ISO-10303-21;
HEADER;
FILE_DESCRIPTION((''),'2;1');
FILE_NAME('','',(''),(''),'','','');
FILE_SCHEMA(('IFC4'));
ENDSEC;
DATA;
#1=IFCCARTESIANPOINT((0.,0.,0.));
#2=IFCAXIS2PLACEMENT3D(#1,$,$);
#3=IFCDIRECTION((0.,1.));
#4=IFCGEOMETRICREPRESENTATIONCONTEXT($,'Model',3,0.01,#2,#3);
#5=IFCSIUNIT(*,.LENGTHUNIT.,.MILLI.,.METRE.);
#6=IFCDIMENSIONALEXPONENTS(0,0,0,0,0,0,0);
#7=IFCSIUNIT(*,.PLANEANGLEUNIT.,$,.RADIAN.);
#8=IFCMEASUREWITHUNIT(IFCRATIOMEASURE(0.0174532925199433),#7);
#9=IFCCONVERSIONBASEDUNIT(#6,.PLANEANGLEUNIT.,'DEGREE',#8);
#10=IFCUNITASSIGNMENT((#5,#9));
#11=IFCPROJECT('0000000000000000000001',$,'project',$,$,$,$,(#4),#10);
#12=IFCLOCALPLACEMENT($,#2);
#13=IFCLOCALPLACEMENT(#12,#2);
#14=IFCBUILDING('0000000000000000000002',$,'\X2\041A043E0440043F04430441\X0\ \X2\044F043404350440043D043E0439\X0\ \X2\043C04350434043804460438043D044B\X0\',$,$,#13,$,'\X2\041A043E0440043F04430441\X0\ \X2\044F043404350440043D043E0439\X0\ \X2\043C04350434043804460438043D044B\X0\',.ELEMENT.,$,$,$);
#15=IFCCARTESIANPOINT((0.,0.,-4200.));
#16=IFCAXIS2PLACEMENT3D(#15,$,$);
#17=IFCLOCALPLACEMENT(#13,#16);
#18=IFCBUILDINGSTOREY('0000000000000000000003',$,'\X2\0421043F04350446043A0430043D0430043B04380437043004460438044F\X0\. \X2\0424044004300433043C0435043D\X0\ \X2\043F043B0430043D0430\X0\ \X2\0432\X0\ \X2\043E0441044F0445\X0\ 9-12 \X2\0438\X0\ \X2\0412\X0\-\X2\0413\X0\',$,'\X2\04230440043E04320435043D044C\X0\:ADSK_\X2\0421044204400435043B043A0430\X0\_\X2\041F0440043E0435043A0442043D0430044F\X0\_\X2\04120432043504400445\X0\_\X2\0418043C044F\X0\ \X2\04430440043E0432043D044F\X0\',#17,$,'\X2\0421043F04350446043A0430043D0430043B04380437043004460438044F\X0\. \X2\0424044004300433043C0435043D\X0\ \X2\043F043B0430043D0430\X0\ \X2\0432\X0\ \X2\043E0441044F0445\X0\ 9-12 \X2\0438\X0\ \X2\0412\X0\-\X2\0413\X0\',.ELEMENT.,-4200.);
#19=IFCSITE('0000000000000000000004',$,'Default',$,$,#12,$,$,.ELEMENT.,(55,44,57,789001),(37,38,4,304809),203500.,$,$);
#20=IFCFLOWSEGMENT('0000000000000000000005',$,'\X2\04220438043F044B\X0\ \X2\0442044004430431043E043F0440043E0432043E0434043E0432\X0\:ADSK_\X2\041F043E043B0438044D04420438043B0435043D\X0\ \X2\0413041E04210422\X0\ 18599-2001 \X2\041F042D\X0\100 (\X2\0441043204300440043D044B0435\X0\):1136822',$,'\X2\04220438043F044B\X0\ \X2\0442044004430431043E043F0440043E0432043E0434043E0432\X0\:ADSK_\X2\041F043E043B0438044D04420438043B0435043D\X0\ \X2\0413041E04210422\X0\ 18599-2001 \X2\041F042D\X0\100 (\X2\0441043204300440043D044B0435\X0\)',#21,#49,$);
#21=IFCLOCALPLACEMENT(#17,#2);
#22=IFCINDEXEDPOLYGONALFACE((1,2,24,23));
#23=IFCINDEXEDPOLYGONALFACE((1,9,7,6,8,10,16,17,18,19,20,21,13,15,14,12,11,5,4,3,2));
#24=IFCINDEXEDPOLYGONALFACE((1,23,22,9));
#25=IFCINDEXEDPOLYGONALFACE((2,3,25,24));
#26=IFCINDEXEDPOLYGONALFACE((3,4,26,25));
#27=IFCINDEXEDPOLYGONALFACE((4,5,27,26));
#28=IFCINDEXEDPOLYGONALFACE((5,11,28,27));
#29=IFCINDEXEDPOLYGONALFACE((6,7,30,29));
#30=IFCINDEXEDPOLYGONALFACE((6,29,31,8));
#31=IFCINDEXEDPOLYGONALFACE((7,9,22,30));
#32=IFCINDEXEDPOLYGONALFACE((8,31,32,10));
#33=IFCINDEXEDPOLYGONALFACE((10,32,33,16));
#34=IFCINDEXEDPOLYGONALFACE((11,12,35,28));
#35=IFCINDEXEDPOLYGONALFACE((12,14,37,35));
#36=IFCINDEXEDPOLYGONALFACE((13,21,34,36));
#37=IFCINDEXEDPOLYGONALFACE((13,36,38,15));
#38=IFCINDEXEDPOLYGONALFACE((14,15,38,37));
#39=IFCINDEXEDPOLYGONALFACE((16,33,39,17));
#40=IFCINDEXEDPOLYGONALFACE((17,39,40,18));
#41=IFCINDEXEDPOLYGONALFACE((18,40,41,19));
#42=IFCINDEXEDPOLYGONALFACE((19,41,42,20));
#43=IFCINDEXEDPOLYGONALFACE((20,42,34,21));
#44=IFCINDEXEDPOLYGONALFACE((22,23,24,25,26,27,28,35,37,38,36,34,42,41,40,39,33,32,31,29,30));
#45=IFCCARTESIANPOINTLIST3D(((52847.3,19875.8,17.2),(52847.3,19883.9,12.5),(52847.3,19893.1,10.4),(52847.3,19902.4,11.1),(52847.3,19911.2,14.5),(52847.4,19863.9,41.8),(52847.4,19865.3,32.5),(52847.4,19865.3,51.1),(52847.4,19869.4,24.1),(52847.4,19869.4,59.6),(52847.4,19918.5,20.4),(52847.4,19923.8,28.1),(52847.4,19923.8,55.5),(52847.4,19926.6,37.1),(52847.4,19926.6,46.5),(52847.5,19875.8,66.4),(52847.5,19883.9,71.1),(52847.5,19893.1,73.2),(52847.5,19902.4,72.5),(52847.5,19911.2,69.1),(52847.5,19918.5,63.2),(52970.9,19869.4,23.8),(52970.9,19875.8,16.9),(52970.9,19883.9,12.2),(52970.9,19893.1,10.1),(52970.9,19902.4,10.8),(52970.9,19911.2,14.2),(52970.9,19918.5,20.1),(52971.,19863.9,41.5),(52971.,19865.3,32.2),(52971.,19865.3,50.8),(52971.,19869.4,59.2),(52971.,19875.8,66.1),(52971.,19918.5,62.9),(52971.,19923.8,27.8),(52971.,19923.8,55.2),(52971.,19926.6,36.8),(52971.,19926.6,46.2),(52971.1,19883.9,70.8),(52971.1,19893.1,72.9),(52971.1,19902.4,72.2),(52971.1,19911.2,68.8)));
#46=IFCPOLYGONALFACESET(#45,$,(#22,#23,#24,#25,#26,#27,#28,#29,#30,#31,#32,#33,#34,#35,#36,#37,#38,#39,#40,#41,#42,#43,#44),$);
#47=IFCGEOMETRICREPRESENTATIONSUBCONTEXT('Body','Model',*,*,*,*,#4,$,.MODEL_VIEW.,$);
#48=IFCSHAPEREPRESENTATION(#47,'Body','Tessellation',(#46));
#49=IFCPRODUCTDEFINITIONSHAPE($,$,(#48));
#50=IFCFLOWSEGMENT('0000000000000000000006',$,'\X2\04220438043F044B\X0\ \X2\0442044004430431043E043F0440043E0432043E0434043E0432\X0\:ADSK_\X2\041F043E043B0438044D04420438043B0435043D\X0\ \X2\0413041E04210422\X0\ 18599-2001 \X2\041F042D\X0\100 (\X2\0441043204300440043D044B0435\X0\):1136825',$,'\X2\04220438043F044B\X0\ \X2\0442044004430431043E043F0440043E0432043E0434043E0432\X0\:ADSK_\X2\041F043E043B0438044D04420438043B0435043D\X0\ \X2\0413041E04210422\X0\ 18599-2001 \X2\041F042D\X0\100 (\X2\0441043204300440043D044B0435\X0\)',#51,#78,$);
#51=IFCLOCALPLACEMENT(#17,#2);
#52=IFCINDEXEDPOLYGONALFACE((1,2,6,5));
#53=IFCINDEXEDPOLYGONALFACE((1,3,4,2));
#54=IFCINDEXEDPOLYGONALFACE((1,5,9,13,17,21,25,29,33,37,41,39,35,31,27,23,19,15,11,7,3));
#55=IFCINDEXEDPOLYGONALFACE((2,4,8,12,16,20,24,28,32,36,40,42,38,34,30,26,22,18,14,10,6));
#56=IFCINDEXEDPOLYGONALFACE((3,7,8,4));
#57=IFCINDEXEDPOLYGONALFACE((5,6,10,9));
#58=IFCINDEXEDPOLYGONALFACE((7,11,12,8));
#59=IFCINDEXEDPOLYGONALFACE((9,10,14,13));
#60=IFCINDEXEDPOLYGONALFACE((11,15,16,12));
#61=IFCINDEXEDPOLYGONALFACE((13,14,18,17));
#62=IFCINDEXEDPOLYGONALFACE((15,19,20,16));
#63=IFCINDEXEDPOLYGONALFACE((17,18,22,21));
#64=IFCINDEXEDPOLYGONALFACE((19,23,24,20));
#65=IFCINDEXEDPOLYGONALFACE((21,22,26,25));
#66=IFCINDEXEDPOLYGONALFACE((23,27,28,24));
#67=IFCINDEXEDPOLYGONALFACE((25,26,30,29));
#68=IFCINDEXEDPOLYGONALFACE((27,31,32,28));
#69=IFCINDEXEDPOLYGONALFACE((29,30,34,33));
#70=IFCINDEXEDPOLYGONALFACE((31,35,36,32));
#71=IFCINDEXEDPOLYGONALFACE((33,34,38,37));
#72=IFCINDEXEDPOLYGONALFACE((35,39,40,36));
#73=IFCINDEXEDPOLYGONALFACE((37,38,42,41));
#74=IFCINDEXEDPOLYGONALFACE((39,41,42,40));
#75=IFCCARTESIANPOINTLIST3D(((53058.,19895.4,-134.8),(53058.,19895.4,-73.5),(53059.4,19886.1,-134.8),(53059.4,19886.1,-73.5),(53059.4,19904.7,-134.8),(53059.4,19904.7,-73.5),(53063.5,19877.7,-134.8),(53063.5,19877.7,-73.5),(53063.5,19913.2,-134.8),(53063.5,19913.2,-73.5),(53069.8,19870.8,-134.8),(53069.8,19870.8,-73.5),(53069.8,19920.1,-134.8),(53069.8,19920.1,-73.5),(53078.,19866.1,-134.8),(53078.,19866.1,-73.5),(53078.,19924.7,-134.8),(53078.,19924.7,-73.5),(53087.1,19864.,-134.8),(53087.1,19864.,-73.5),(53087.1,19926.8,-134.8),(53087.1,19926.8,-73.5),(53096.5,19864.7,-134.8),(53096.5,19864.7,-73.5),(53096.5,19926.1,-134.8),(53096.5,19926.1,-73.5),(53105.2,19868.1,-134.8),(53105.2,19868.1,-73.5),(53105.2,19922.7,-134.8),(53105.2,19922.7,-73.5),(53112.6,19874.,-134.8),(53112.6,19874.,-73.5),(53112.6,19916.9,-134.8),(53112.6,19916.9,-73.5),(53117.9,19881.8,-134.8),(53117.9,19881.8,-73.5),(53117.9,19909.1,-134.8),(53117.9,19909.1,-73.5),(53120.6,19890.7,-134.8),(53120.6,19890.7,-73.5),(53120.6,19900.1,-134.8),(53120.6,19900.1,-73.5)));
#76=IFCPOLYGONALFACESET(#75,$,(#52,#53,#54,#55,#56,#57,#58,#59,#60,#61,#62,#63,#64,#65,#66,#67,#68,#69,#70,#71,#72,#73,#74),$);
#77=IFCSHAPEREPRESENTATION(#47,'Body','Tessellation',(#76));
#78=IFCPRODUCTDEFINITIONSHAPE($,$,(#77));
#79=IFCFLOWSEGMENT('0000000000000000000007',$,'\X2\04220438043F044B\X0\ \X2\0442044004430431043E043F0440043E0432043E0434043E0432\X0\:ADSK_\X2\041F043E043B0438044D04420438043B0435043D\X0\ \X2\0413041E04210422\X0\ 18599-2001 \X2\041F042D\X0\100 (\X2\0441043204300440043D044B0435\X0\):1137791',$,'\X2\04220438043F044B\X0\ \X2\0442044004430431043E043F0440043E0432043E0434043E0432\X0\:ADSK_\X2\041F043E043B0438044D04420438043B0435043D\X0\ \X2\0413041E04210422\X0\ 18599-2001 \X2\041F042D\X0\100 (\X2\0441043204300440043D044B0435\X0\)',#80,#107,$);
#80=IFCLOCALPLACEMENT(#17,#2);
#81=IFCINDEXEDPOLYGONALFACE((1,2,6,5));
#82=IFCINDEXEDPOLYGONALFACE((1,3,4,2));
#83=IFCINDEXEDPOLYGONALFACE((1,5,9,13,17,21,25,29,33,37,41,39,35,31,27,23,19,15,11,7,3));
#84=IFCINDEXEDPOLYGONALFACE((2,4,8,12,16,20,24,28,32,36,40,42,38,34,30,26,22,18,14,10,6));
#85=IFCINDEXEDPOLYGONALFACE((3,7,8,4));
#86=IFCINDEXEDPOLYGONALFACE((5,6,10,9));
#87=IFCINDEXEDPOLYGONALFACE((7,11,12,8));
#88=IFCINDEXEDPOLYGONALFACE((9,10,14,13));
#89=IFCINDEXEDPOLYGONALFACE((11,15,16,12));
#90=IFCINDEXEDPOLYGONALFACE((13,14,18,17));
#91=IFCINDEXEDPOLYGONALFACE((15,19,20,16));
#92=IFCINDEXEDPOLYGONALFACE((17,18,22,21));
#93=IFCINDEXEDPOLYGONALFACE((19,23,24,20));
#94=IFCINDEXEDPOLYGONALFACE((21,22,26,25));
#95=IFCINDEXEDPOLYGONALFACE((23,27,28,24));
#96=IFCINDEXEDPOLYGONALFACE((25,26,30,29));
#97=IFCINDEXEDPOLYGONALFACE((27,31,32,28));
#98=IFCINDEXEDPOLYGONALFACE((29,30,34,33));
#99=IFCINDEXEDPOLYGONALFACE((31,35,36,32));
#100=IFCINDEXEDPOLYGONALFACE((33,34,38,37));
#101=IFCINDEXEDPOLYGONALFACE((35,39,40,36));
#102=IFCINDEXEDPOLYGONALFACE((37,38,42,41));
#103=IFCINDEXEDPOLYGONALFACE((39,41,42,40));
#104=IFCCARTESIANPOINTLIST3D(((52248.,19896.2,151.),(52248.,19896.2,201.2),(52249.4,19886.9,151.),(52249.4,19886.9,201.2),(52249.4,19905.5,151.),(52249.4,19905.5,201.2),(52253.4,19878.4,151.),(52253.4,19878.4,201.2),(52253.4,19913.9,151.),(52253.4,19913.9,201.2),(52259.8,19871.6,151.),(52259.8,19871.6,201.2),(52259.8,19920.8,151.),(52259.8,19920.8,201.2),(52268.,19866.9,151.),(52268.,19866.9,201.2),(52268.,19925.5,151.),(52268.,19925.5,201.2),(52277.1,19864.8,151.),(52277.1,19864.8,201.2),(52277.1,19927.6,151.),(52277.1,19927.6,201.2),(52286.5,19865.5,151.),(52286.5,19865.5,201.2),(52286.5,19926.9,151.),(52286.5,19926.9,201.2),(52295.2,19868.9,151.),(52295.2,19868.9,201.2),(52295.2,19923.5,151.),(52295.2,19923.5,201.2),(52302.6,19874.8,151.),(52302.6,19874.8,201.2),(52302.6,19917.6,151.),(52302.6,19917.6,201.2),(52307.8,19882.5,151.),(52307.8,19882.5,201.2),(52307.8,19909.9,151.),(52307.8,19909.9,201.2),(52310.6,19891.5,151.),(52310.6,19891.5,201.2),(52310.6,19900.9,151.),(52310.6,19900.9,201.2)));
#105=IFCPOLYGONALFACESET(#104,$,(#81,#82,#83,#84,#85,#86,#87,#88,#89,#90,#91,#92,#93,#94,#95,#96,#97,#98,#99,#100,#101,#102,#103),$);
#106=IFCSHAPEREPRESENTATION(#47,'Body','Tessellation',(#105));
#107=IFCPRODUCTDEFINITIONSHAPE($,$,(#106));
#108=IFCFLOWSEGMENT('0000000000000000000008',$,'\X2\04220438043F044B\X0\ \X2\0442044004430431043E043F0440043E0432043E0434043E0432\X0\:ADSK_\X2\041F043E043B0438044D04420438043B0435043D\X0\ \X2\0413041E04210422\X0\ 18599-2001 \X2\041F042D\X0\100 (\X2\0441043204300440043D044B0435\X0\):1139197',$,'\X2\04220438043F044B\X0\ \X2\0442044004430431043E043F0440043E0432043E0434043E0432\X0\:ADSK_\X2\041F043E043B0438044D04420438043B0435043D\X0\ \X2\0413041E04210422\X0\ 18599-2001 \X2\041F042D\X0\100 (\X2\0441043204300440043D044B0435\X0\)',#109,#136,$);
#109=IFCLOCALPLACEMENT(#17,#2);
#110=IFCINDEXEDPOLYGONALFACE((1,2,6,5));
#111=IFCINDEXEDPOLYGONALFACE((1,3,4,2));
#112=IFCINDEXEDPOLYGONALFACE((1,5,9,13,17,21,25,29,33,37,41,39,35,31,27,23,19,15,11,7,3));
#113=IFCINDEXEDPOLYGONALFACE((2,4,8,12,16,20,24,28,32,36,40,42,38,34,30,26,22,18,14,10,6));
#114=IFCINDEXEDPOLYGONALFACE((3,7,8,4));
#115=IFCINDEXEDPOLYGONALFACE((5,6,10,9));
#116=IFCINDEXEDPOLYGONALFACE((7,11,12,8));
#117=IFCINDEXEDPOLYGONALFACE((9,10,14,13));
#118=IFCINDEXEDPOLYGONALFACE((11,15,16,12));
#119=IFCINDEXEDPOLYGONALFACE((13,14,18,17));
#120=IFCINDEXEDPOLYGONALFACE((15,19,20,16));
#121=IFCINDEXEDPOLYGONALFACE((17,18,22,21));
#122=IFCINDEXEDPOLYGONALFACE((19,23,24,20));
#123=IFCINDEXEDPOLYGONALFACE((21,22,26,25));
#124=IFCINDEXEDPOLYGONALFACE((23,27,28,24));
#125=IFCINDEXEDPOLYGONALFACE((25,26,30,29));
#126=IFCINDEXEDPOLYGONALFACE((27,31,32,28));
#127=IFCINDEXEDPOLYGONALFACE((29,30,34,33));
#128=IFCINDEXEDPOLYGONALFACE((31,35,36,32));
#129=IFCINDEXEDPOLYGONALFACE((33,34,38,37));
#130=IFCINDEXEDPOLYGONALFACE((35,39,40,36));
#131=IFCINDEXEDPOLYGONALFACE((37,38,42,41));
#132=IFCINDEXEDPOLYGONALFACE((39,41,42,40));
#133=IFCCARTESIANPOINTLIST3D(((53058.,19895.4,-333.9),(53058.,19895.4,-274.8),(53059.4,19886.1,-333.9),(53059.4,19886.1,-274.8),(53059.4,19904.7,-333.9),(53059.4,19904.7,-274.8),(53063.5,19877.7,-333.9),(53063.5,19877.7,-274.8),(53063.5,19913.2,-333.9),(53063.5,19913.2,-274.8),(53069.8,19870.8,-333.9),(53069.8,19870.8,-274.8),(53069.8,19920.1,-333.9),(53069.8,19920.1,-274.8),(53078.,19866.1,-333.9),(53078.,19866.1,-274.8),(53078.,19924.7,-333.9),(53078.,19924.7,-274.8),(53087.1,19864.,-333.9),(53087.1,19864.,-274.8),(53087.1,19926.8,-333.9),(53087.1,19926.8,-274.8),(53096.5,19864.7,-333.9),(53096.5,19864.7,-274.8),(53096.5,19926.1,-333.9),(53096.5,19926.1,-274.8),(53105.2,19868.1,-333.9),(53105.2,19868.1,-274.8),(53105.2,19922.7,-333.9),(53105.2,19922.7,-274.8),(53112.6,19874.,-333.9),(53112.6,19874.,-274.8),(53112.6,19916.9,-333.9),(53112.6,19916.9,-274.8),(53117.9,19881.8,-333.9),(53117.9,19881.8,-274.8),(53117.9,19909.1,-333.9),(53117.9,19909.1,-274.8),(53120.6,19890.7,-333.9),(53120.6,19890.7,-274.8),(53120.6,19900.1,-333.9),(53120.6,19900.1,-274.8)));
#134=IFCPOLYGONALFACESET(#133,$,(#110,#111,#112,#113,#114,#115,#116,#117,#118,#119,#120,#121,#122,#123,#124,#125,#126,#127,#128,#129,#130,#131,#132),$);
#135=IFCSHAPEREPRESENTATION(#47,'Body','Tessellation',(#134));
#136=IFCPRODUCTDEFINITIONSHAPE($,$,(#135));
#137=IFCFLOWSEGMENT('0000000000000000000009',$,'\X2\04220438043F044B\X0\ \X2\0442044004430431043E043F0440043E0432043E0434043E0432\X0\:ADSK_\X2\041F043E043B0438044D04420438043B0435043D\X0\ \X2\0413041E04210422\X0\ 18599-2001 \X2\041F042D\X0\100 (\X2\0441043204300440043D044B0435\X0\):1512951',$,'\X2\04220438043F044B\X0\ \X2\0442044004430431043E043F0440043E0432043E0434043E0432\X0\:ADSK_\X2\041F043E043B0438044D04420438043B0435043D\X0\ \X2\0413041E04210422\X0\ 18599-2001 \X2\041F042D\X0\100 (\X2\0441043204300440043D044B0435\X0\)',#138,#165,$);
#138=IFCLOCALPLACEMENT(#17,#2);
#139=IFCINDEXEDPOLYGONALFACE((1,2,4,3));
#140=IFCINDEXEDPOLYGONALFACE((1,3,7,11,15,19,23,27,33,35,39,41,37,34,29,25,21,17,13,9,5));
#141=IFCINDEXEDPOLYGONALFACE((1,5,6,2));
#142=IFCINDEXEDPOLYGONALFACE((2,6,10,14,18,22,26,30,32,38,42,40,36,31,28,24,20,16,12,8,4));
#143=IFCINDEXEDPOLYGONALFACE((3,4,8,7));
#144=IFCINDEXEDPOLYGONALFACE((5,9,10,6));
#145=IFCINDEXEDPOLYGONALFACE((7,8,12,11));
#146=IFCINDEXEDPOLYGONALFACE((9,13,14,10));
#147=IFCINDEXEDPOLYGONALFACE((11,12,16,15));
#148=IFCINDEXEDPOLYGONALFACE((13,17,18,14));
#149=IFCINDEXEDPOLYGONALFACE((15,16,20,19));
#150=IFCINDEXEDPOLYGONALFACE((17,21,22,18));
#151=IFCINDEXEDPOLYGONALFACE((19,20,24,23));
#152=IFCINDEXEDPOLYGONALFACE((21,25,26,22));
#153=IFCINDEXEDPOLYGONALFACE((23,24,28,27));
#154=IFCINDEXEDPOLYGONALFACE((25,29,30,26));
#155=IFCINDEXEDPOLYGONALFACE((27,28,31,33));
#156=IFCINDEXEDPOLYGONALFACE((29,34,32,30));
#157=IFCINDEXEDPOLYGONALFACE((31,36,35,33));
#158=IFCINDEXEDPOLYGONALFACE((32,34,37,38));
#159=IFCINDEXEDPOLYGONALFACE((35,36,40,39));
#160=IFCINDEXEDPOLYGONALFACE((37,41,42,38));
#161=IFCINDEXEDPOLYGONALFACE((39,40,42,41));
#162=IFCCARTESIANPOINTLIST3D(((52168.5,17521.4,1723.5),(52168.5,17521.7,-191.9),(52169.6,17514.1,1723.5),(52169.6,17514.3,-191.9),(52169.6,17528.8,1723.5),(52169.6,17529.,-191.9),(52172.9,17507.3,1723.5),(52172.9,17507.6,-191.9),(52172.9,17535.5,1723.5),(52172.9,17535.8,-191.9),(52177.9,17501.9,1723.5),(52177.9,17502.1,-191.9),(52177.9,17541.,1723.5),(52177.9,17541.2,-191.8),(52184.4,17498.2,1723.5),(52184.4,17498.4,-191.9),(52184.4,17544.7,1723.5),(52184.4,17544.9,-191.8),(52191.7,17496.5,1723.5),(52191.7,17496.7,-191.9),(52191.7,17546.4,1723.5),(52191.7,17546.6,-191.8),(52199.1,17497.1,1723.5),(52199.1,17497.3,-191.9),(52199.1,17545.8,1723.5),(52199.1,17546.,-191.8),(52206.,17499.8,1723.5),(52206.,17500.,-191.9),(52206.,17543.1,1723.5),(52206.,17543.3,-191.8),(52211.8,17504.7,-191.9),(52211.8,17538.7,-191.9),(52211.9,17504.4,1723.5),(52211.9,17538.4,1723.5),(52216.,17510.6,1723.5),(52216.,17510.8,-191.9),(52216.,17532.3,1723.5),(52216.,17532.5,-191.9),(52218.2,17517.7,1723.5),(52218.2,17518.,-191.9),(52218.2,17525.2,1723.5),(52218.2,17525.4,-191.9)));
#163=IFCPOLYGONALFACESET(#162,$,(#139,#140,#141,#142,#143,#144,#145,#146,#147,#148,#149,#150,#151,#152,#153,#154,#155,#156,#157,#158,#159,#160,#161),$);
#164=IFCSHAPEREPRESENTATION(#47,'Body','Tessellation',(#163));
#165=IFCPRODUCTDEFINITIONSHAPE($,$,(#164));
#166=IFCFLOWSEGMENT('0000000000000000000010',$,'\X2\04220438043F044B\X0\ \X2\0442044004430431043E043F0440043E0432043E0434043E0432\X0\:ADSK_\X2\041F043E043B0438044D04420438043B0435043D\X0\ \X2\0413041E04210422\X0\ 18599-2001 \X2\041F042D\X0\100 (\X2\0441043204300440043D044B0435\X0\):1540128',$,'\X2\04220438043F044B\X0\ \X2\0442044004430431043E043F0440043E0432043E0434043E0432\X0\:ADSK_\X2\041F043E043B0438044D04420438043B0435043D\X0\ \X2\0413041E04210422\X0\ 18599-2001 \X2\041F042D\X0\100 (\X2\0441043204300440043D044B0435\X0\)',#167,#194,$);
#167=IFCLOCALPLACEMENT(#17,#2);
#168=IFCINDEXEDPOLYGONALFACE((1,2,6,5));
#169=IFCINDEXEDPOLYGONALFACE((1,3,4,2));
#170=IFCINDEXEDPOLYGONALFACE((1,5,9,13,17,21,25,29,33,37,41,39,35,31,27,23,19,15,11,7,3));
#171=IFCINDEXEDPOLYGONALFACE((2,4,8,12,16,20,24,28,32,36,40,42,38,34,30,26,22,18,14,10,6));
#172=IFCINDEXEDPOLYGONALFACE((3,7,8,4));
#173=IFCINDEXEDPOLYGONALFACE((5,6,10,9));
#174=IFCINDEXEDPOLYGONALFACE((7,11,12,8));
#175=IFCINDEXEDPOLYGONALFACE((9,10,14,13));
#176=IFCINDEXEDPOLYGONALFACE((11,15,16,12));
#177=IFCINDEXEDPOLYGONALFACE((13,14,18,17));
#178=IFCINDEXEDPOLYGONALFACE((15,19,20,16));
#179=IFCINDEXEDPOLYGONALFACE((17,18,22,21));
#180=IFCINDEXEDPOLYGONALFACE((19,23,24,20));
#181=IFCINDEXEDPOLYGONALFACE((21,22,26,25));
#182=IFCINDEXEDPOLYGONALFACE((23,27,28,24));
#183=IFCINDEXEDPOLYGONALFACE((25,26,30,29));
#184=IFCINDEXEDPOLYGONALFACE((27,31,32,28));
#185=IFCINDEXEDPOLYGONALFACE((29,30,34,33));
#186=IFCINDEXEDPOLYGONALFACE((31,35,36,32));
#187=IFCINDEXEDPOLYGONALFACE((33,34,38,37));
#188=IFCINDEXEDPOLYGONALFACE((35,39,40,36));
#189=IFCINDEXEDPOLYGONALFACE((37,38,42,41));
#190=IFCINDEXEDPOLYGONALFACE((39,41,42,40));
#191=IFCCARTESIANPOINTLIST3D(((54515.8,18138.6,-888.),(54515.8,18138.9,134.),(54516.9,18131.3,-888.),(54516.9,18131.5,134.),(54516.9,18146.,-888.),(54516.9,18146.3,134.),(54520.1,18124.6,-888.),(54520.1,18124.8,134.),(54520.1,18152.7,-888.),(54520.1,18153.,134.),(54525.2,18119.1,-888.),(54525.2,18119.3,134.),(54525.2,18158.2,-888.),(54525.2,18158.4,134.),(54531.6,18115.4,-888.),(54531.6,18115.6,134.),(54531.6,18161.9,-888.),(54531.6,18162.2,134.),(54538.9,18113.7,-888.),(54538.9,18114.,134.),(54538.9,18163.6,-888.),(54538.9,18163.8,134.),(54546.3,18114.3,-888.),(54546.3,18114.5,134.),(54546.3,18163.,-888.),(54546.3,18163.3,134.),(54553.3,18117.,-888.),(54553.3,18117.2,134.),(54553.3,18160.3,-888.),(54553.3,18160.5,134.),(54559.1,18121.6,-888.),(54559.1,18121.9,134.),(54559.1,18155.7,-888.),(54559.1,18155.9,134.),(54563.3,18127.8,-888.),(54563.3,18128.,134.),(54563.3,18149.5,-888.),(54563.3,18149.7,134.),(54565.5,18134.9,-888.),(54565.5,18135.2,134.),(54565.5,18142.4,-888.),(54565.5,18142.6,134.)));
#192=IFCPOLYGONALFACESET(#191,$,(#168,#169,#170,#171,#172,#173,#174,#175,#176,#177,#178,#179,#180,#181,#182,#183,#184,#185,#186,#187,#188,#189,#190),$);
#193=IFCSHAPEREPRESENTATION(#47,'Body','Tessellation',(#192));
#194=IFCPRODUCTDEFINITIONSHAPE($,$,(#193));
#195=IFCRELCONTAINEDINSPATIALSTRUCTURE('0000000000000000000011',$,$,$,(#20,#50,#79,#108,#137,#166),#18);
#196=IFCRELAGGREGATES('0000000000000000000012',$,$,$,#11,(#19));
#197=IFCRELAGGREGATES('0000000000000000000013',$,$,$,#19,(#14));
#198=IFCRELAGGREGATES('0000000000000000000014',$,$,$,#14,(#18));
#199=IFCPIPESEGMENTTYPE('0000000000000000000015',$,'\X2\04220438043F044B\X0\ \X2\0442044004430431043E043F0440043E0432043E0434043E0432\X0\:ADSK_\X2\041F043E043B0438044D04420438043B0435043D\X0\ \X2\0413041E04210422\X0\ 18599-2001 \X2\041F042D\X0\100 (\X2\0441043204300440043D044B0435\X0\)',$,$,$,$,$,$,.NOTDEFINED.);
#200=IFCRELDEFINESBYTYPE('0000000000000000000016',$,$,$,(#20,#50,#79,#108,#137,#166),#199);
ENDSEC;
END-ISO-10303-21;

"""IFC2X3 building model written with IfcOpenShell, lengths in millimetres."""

from ifc_helpers import new_model, entity, si_unit, converted_unit, direction, frame, frame_2d, origin, origin_2d_with_axis, place, context, subcontext, project, spatial, circle, extrude, type_object, element, save


model = new_model("IFC2X3")

# Units and contexts
model_context = context("Model", 3, precision=0.01, world=origin(), true_north=direction((0.0, 1.0)))
body_context = subcontext(model_context, "Body", "Model", "MODEL_VIEW")
ifc_project = project(units=[si_unit("LENGTHUNIT", "METRE", prefix="MILLI"), converted_unit("PLANEANGLEUNIT", "DEGREE", entity("IfcRatioMeasure", 0.0174532925199433), si_unit("PLANEANGLEUNIT", "RADIAN"), dimensions=[0, 0, 0, 0, 0, 0, 0])], contexts=[model_context])

# Site, building, storey
site_placement = place(None, frame((0.0, 0.0, 0.0)))
site = spatial("IfcSite", under=ifc_project, at=site_placement, Name="Default", CompositionType="ELEMENT", RefLatitude=(55, 44, 57, 789001), RefLongitude=(37, 38, 4, 304809), RefElevation=203500.0)
building_placement = place(site_placement, origin())
building = spatial("IfcBuilding", under=site, at=building_placement, Name="Корпус ядерной медицины", LongName="Корпус ядерной медицины", CompositionType="ELEMENT")
storey_placement = place(building_placement, frame((0.0, 0.0, -4200.0)))
storey = spatial("IfcBuildingStorey", under=building, at=storey_placement, Name="Спецканализация. Фрагмен плана в осях 9-12 и В-Г", ObjectType="Уровень:ADSK_Стрелка_Проектная_Вверх_Имя уровня", LongName="Спецканализация. Фрагмен плана в осях 9-12 и В-Г", CompositionType="ELEMENT", Elevation=-4200.0)

# Flow segments
pipe_segment_type = type_object("IfcPipeSegmentType", Name="Типы трубопроводов:ADSK_Полиэтилен ГОСТ 18599-2001 ПЭ100 (сварные)", PredefinedType="NOTDEFINED")
flow_segment_1_placement = place(storey_placement, frame((52847.3, 19862.3, 8.4)))
element("IfcFlowSegment", 1, at=flow_segment_1_placement, inside=storey, type_object=pipe_segment_type, Name="Типы трубопроводов:ADSK_Полиэтилен ГОСТ 18599-2001 ПЭ100 (сварные):1136822", ObjectType="Типы трубопроводов:ADSK_Полиэтилен ГОСТ 18599-2001 ПЭ100 (сварные)", context=body_context, shape_type="SweptSolid", body=[
    extrude(circle(Radius=31.5, at=origin_2d_with_axis()), frame((0.1, 33.1, 33.4), z_axis=(0.999997, 0.0, -0.002457), x_axis=(0.0, -1.0, 0.0)), (0.0, 0.0, 1.0), 123.6),
])
flow_segment_2_placement = place(storey_placement, frame((53056.4, 19862.3, -134.8)))
element("IfcFlowSegment", 2, at=flow_segment_2_placement, inside=storey, type_object=pipe_segment_type, Name="Типы трубопроводов:ADSK_Полиэтилен ГОСТ 18599-2001 ПЭ100 (сварные):1136825", ObjectType="Типы трубопроводов:ADSK_Полиэтилен ГОСТ 18599-2001 ПЭ100 (сварные)", context=body_context, shape_type="SweptSolid", body=[
    extrude(circle(Radius=31.5, at=origin_2d_with_axis()), frame((33.1, 33.1, 0.0), z_axis=(-0.000005, 0.0, 1.0), x_axis=(-1.0, 0.0, -0.000005)), (0.0, 0.0, 1.0), 61.3),
])
flow_segment_3_placement = place(storey_placement, frame((52246.4, 19863.1, 151.0)))
element("IfcFlowSegment", 3, at=flow_segment_3_placement, inside=storey, type_object=pipe_segment_type, Name="Типы трубопроводов:ADSK_Полиэтилен ГОСТ 18599-2001 ПЭ100 (сварные):1137791", ObjectType="Типы трубопроводов:ADSK_Полиэтилен ГОСТ 18599-2001 ПЭ100 (сварные)", context=body_context, shape_type="SweptSolid", body=[
    extrude(circle(Radius=31.5, at=frame_2d((0.0, 0.0), x_axis=(1.0, 0.0))), frame((33.1, 33.1, 0.0), z_axis=(-0.000008, 0.0, 1.0), x_axis=(-1.0, 0.0, -0.000008)), (0.0, 0.0, 1.0), 50.2),
])
flow_segment_4_placement = place(storey_placement, frame((53056.4, 19862.3, -333.9)))
element("IfcFlowSegment", 4, at=flow_segment_4_placement, inside=storey, type_object=pipe_segment_type, Name="Типы трубопроводов:ADSK_Полиэтилен ГОСТ 18599-2001 ПЭ100 (сварные):1139197", ObjectType="Типы трубопроводов:ADSK_Полиэтилен ГОСТ 18599-2001 ПЭ100 (сварные)", context=body_context, shape_type="SweptSolid", body=[
    extrude(circle(Radius=31.5, at=origin_2d_with_axis()), frame((33.1, 33.1, 0.0), z_axis=(0.000005, 0.0, 1.0), x_axis=(-1.0, 0.0, 0.000005)), (0.0, 0.0, 1.0), 59.1),
])
flow_segment_5_placement = place(storey_placement, frame((52166.9, 17494.8, -191.9)))
element("IfcFlowSegment", 5, at=flow_segment_5_placement, inside=storey, type_object=pipe_segment_type, Name="Типы трубопроводов:ADSK_Полиэтилен ГОСТ 18599-2001 ПЭ100 (сварные):1512951", ObjectType="Типы трубопроводов:ADSK_Полиэтилен ГОСТ 18599-2001 ПЭ100 (сварные)", context=body_context, shape_type="SweptSolid", body=[
    extrude(circle(Radius=25.0, at=origin_2d_with_axis()), frame((26.6, 26.8, 0.0), z_axis=(0.000001, -0.00013, 1.0), x_axis=(-1.0, 0.0, 0.000001)), (0.0, 0.0, 1.0), 1915.3),
])
flow_segment_6_placement = place(storey_placement, frame((54514.2, 18112.1, -888.0)))
element("IfcFlowSegment", 6, at=flow_segment_6_placement, inside=storey, type_object=pipe_segment_type, Name="Типы трубопроводов:ADSK_Полиэтилен ГОСТ 18599-2001 ПЭ100 (сварные):1540128", ObjectType="Типы трубопроводов:ADSK_Полиэтилен ГОСТ 18599-2001 ПЭ100 (сварные)", context=body_context, shape_type="SweptSolid", body=[
    extrude(circle(Radius=25.0, at=frame_2d((0.0, 0.0), x_axis=(1.0, 0.0))), frame((26.6, 26.6, 0.0), z_axis=(0.0, 0.000233, 1.0), x_axis=(-1.0, 0.0, 0.0)), (0.0, 0.0, 1.0), 1022.1),
])

save(model, "model.ifc")
